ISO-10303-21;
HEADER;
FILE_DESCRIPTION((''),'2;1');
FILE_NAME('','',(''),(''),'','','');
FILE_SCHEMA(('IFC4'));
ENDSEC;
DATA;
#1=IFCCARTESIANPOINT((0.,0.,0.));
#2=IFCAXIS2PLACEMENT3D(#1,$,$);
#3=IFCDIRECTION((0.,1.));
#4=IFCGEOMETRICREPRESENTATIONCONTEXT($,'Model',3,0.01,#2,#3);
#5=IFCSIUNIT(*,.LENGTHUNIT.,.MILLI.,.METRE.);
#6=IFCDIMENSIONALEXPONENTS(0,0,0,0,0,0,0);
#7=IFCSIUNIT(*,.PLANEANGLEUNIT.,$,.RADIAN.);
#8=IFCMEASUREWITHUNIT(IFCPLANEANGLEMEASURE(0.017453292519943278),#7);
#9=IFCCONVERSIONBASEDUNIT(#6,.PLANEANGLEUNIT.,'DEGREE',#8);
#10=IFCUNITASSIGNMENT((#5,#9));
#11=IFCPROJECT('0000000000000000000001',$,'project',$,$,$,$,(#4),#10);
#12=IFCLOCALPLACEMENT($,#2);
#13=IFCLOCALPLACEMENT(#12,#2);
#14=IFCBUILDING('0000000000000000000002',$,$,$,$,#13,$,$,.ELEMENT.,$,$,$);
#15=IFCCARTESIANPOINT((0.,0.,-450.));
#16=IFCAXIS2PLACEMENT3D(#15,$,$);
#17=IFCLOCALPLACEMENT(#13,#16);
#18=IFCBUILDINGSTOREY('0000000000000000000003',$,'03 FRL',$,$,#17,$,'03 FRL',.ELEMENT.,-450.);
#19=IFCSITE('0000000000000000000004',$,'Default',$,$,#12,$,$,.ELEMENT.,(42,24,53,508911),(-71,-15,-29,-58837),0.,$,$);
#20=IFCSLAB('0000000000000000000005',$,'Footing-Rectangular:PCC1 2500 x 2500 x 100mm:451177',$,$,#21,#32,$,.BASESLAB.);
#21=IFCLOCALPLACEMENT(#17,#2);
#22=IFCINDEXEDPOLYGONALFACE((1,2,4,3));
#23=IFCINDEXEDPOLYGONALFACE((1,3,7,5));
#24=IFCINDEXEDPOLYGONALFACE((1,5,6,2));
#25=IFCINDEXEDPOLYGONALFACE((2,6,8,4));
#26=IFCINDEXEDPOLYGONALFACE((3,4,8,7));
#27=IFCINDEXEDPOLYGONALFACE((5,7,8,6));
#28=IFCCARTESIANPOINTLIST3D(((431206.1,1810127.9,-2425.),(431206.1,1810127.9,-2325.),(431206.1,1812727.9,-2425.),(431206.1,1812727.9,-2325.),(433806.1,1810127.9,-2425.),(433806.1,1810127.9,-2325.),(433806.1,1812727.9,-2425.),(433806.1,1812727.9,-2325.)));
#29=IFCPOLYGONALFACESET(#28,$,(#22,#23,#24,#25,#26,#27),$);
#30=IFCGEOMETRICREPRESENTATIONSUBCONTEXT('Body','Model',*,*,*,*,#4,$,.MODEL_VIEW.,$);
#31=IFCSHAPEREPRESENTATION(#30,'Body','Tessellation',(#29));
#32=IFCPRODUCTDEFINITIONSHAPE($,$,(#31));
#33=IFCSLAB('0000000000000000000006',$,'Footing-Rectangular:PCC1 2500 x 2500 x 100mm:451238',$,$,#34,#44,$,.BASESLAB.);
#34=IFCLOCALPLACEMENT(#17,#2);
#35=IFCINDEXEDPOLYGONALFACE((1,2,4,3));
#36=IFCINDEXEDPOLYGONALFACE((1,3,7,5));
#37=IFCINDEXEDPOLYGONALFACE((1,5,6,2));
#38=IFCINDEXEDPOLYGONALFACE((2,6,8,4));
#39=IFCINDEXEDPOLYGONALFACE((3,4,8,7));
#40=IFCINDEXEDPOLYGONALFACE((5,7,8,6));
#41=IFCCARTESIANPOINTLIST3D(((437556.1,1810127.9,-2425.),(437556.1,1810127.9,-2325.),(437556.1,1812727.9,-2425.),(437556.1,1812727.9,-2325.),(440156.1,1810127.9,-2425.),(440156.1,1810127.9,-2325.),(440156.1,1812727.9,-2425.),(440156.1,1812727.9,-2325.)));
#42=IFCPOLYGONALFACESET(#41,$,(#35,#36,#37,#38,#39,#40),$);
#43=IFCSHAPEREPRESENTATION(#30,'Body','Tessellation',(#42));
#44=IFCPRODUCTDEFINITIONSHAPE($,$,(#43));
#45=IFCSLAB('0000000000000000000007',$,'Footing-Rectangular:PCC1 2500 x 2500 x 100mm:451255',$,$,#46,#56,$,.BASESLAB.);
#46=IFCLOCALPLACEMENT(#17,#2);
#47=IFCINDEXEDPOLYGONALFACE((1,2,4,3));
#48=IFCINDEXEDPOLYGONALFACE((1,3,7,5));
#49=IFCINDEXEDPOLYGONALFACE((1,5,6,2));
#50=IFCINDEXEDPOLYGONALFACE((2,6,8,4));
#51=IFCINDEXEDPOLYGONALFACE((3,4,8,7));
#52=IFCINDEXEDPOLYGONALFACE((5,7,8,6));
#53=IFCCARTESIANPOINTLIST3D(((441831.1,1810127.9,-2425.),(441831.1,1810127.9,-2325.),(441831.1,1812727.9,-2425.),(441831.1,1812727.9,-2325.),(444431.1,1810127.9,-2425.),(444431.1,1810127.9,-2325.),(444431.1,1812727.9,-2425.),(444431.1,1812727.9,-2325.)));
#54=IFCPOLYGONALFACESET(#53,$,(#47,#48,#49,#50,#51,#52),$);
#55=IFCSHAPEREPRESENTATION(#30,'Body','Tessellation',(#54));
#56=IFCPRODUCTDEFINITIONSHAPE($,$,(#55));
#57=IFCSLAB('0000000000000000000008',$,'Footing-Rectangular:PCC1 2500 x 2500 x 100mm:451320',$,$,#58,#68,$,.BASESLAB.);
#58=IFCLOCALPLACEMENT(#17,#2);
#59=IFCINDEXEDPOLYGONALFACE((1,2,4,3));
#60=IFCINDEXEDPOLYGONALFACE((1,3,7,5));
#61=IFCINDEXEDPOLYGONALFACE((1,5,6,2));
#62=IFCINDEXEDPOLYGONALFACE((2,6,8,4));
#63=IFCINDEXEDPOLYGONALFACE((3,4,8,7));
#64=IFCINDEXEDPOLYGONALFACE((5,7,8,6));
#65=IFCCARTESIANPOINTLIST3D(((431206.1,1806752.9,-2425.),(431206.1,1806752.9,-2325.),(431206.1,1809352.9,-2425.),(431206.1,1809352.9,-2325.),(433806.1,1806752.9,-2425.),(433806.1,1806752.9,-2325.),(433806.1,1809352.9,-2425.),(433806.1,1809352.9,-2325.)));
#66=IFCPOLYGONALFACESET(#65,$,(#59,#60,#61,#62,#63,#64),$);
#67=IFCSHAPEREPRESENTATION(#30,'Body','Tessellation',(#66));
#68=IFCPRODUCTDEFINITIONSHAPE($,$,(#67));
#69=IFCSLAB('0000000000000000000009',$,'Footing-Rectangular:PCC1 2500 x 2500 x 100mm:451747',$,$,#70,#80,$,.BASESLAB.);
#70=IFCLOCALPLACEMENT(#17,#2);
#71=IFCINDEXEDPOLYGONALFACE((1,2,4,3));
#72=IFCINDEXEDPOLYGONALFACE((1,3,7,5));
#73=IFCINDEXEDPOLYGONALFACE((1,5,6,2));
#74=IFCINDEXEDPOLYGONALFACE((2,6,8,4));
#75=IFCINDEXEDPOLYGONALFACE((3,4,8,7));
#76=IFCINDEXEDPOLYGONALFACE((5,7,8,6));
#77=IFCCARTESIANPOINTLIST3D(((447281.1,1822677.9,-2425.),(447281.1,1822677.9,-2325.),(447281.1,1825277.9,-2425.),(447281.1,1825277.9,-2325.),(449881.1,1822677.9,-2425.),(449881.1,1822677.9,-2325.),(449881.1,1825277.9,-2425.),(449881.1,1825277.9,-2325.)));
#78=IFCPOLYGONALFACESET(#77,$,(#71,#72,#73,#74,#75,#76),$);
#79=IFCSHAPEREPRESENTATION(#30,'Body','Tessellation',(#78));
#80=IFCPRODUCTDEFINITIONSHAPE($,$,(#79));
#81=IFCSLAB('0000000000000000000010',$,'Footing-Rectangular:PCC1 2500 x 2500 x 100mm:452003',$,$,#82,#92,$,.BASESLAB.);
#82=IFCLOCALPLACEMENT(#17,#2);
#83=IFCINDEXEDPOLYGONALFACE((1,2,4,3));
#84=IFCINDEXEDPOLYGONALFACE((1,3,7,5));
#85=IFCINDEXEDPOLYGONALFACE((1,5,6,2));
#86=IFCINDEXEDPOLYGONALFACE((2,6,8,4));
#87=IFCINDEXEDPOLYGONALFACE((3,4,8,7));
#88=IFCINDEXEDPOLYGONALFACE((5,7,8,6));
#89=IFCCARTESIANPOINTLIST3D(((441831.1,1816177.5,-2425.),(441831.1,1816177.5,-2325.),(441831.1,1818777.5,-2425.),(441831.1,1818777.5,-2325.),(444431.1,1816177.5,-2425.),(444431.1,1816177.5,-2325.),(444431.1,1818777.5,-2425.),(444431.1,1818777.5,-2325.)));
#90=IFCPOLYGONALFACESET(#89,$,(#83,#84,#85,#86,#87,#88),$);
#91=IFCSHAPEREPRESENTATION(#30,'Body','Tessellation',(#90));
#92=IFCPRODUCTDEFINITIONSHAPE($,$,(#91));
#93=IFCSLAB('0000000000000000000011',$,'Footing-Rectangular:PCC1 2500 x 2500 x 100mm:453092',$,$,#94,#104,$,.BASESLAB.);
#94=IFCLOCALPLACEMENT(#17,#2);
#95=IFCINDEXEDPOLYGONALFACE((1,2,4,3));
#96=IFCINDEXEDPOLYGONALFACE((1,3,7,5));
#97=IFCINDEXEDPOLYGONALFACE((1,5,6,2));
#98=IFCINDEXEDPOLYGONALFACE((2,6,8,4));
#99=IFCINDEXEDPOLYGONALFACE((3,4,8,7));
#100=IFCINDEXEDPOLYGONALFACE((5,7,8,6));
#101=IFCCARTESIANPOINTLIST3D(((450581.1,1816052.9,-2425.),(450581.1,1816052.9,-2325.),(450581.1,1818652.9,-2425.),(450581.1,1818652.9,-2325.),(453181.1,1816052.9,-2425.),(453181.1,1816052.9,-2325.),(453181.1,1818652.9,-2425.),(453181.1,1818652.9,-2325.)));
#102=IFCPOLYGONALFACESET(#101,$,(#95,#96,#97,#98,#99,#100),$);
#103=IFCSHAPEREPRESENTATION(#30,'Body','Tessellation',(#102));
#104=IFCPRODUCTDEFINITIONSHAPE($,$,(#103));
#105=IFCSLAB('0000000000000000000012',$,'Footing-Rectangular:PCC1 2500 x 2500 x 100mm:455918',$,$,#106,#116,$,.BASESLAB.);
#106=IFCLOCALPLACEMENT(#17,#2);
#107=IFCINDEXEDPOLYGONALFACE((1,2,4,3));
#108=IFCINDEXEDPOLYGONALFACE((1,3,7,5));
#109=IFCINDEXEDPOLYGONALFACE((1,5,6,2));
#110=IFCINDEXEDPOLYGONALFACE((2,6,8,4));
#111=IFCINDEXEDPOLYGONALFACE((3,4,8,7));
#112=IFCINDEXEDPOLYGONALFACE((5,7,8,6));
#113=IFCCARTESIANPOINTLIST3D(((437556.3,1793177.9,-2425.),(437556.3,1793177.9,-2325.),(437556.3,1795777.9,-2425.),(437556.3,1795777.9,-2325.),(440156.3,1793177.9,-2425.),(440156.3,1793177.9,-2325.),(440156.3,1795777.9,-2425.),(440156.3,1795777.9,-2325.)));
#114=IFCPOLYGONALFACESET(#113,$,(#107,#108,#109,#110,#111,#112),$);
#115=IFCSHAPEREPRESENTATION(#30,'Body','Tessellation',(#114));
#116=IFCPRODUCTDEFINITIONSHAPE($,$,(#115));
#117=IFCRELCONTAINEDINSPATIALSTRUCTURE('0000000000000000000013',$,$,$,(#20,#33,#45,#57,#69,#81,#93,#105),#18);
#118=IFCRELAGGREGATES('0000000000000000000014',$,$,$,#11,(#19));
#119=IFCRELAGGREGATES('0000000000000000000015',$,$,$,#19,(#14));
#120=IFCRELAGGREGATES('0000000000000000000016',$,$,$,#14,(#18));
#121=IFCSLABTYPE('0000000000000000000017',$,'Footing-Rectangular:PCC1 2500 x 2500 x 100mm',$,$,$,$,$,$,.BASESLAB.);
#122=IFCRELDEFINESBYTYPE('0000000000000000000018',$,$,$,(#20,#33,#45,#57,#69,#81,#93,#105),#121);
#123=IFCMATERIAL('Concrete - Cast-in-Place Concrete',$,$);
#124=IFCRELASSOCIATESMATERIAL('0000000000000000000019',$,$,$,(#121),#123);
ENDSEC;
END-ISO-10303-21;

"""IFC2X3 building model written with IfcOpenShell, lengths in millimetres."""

from ifc_helpers import new_model, entity, si_unit, converted_unit, direction, frame, frame_2d, origin, place, context, subcontext, project, spatial, rectangle, extrude, material, type_object, element, save


model = new_model("IFC2X3")

# Units and contexts
model_context = context("Model", 3, precision=0.01, world=origin(), true_north=direction((0.0, 1.0)))
body_context = subcontext(model_context, "Body", "Model", "MODEL_VIEW")
ifc_project = project(units=[si_unit("LENGTHUNIT", "METRE", prefix="MILLI"), converted_unit("PLANEANGLEUNIT", "DEGREE", entity("IfcPlaneAngleMeasure", 0.017453292519943278), si_unit("PLANEANGLEUNIT", "RADIAN"), dimensions=[0, 0, 0, 0, 0, 0, 0])], contexts=[model_context])

# Site, building, storey
site_placement = place(None, origin())
site = spatial("IfcSite", under=ifc_project, at=site_placement, Name="Default", CompositionType="ELEMENT", RefLatitude=(42, 24, 53, 508911), RefLongitude=(-71, -15, -29, -58837), RefElevation=0.0)
building_placement = place(site_placement, origin())
building = spatial("IfcBuilding", under=site, at=building_placement, CompositionType="ELEMENT")
storey_placement = place(building_placement, frame((0.0, 0.0, -450.0)))
storey = spatial("IfcBuildingStorey", under=building, at=storey_placement, Name="03 FRL", LongName="03 FRL", CompositionType="ELEMENT", Elevation=-450.0)

# Slabs
ifc_material = material(Name="Concrete - Cast-in-Place Concrete")
slab_type = type_object("IfcSlabType", Name="Footing-Rectangular:PCC1 2500 x 2500 x 100mm", PredefinedType="BASESLAB", material=ifc_material)
slab_1_placement = place(storey_placement, origin())
element("IfcSlab", 1, at=slab_1_placement, inside=storey, type_object=slab_type, Name="Footing-Rectangular:PCC1 2500 x 2500 x 100mm:451177", PredefinedType="BASESLAB", context=body_context, shape_type="SweptSolid", body=[
    extrude(rectangle(XDim=2600.0, YDim=2600.0, at=frame_2d((0.0, 0.0), x_axis=(1.0, 0.0))), frame((432506.1, 1811427.9, -2425.0), z_axis=(0.0, 0.0, 1.0), x_axis=(-1.0, 0.0, 0.0)), (0.0, 0.0, 1.0), 100.0),
])
slab_2_placement = place(storey_placement, origin())
element("IfcSlab", 2, at=slab_2_placement, inside=storey, type_object=slab_type, Name="Footing-Rectangular:PCC1 2500 x 2500 x 100mm:451238", PredefinedType="BASESLAB", context=body_context, shape_type="SweptSolid", body=[
    extrude(rectangle(XDim=2600.0, YDim=2600.0, at=frame_2d((0.0, 0.0), x_axis=(1.0, 0.0))), frame((438856.1, 1811427.9, -2425.0), z_axis=(0.0, 0.0, 1.0), x_axis=(-1.0, 0.0, 0.0)), (0.0, 0.0, 1.0), 100.0),
])
slab_3_placement = place(storey_placement, origin())
element("IfcSlab", 3, at=slab_3_placement, inside=storey, type_object=slab_type, Name="Footing-Rectangular:PCC1 2500 x 2500 x 100mm:451255", PredefinedType="BASESLAB", context=body_context, shape_type="SweptSolid", body=[
    extrude(rectangle(XDim=2600.0, YDim=2600.0, at=frame_2d((0.0, 0.0), x_axis=(1.0, 0.0))), frame((443131.1, 1811427.9, -2425.0), z_axis=(0.0, 0.0, 1.0), x_axis=(-1.0, 0.0, 0.0)), (0.0, 0.0, 1.0), 100.0),
])
slab_4_placement = place(storey_placement, origin())
element("IfcSlab", 4, at=slab_4_placement, inside=storey, type_object=slab_type, Name="Footing-Rectangular:PCC1 2500 x 2500 x 100mm:451320", PredefinedType="BASESLAB", context=body_context, shape_type="SweptSolid", body=[
    extrude(rectangle(XDim=2600.0, YDim=2600.0, at=frame_2d((0.0, 0.0), x_axis=(1.0, 0.0))), frame((432506.1, 1808052.9, -2425.0), z_axis=(0.0, 0.0, 1.0), x_axis=(-1.0, 0.0, 0.0)), (0.0, 0.0, 1.0), 100.0),
])
slab_5_placement = place(storey_placement, origin())
element("IfcSlab", 5, at=slab_5_placement, inside=storey, type_object=slab_type, Name="Footing-Rectangular:PCC1 2500 x 2500 x 100mm:451747", PredefinedType="BASESLAB", context=body_context, shape_type="SweptSolid", body=[
    extrude(rectangle(XDim=2600.0, YDim=2600.0, at=frame_2d((0.0, 0.0), x_axis=(1.0, 0.0))), frame((448581.1, 1823977.9, -2425.0), z_axis=(0.0, 0.0, 1.0), x_axis=(-1.0, 0.0, 0.0)), (0.0, 0.0, 1.0), 100.0),
])
slab_6_placement = place(storey_placement, origin())
element("IfcSlab", 6, at=slab_6_placement, inside=storey, type_object=slab_type, Name="Footing-Rectangular:PCC1 2500 x 2500 x 100mm:452003", PredefinedType="BASESLAB", context=body_context, shape_type="SweptSolid", body=[
    extrude(rectangle(XDim=2600.0, YDim=2600.0, at=frame_2d((0.0, 0.0), x_axis=(1.0, 0.0))), frame((443131.1, 1817477.5, -2425.0), z_axis=(0.0, 0.0, 1.0), x_axis=(-1.0, 0.0, 0.0)), (0.0, 0.0, 1.0), 100.0),
])
slab_7_placement = place(storey_placement, origin())
element("IfcSlab", 7, at=slab_7_placement, inside=storey, type_object=slab_type, Name="Footing-Rectangular:PCC1 2500 x 2500 x 100mm:453092", PredefinedType="BASESLAB", context=body_context, shape_type="SweptSolid", body=[
    extrude(rectangle(XDim=2600.0, YDim=2600.0, at=frame_2d((0.0, 0.0), x_axis=(1.0, 0.0))), frame((451881.1, 1817352.9, -2425.0), z_axis=(0.0, 0.0, 1.0), x_axis=(-1.0, 0.0, 0.0)), (0.0, 0.0, 1.0), 100.0),
])
slab_8_placement = place(storey_placement, origin())
element("IfcSlab", 8, at=slab_8_placement, inside=storey, type_object=slab_type, Name="Footing-Rectangular:PCC1 2500 x 2500 x 100mm:455918", PredefinedType="BASESLAB", context=body_context, shape_type="SweptSolid", body=[
    extrude(rectangle(XDim=2600.0, YDim=2600.0, at=frame_2d((0.0, 0.0), x_axis=(1.0, 0.0))), frame((438856.3, 1794477.9, -2425.0), z_axis=(0.0, 0.0, 1.0), x_axis=(-1.0, 0.0, 0.0)), (0.0, 0.0, 1.0), 100.0),
])

save(model, "model.ifc")
